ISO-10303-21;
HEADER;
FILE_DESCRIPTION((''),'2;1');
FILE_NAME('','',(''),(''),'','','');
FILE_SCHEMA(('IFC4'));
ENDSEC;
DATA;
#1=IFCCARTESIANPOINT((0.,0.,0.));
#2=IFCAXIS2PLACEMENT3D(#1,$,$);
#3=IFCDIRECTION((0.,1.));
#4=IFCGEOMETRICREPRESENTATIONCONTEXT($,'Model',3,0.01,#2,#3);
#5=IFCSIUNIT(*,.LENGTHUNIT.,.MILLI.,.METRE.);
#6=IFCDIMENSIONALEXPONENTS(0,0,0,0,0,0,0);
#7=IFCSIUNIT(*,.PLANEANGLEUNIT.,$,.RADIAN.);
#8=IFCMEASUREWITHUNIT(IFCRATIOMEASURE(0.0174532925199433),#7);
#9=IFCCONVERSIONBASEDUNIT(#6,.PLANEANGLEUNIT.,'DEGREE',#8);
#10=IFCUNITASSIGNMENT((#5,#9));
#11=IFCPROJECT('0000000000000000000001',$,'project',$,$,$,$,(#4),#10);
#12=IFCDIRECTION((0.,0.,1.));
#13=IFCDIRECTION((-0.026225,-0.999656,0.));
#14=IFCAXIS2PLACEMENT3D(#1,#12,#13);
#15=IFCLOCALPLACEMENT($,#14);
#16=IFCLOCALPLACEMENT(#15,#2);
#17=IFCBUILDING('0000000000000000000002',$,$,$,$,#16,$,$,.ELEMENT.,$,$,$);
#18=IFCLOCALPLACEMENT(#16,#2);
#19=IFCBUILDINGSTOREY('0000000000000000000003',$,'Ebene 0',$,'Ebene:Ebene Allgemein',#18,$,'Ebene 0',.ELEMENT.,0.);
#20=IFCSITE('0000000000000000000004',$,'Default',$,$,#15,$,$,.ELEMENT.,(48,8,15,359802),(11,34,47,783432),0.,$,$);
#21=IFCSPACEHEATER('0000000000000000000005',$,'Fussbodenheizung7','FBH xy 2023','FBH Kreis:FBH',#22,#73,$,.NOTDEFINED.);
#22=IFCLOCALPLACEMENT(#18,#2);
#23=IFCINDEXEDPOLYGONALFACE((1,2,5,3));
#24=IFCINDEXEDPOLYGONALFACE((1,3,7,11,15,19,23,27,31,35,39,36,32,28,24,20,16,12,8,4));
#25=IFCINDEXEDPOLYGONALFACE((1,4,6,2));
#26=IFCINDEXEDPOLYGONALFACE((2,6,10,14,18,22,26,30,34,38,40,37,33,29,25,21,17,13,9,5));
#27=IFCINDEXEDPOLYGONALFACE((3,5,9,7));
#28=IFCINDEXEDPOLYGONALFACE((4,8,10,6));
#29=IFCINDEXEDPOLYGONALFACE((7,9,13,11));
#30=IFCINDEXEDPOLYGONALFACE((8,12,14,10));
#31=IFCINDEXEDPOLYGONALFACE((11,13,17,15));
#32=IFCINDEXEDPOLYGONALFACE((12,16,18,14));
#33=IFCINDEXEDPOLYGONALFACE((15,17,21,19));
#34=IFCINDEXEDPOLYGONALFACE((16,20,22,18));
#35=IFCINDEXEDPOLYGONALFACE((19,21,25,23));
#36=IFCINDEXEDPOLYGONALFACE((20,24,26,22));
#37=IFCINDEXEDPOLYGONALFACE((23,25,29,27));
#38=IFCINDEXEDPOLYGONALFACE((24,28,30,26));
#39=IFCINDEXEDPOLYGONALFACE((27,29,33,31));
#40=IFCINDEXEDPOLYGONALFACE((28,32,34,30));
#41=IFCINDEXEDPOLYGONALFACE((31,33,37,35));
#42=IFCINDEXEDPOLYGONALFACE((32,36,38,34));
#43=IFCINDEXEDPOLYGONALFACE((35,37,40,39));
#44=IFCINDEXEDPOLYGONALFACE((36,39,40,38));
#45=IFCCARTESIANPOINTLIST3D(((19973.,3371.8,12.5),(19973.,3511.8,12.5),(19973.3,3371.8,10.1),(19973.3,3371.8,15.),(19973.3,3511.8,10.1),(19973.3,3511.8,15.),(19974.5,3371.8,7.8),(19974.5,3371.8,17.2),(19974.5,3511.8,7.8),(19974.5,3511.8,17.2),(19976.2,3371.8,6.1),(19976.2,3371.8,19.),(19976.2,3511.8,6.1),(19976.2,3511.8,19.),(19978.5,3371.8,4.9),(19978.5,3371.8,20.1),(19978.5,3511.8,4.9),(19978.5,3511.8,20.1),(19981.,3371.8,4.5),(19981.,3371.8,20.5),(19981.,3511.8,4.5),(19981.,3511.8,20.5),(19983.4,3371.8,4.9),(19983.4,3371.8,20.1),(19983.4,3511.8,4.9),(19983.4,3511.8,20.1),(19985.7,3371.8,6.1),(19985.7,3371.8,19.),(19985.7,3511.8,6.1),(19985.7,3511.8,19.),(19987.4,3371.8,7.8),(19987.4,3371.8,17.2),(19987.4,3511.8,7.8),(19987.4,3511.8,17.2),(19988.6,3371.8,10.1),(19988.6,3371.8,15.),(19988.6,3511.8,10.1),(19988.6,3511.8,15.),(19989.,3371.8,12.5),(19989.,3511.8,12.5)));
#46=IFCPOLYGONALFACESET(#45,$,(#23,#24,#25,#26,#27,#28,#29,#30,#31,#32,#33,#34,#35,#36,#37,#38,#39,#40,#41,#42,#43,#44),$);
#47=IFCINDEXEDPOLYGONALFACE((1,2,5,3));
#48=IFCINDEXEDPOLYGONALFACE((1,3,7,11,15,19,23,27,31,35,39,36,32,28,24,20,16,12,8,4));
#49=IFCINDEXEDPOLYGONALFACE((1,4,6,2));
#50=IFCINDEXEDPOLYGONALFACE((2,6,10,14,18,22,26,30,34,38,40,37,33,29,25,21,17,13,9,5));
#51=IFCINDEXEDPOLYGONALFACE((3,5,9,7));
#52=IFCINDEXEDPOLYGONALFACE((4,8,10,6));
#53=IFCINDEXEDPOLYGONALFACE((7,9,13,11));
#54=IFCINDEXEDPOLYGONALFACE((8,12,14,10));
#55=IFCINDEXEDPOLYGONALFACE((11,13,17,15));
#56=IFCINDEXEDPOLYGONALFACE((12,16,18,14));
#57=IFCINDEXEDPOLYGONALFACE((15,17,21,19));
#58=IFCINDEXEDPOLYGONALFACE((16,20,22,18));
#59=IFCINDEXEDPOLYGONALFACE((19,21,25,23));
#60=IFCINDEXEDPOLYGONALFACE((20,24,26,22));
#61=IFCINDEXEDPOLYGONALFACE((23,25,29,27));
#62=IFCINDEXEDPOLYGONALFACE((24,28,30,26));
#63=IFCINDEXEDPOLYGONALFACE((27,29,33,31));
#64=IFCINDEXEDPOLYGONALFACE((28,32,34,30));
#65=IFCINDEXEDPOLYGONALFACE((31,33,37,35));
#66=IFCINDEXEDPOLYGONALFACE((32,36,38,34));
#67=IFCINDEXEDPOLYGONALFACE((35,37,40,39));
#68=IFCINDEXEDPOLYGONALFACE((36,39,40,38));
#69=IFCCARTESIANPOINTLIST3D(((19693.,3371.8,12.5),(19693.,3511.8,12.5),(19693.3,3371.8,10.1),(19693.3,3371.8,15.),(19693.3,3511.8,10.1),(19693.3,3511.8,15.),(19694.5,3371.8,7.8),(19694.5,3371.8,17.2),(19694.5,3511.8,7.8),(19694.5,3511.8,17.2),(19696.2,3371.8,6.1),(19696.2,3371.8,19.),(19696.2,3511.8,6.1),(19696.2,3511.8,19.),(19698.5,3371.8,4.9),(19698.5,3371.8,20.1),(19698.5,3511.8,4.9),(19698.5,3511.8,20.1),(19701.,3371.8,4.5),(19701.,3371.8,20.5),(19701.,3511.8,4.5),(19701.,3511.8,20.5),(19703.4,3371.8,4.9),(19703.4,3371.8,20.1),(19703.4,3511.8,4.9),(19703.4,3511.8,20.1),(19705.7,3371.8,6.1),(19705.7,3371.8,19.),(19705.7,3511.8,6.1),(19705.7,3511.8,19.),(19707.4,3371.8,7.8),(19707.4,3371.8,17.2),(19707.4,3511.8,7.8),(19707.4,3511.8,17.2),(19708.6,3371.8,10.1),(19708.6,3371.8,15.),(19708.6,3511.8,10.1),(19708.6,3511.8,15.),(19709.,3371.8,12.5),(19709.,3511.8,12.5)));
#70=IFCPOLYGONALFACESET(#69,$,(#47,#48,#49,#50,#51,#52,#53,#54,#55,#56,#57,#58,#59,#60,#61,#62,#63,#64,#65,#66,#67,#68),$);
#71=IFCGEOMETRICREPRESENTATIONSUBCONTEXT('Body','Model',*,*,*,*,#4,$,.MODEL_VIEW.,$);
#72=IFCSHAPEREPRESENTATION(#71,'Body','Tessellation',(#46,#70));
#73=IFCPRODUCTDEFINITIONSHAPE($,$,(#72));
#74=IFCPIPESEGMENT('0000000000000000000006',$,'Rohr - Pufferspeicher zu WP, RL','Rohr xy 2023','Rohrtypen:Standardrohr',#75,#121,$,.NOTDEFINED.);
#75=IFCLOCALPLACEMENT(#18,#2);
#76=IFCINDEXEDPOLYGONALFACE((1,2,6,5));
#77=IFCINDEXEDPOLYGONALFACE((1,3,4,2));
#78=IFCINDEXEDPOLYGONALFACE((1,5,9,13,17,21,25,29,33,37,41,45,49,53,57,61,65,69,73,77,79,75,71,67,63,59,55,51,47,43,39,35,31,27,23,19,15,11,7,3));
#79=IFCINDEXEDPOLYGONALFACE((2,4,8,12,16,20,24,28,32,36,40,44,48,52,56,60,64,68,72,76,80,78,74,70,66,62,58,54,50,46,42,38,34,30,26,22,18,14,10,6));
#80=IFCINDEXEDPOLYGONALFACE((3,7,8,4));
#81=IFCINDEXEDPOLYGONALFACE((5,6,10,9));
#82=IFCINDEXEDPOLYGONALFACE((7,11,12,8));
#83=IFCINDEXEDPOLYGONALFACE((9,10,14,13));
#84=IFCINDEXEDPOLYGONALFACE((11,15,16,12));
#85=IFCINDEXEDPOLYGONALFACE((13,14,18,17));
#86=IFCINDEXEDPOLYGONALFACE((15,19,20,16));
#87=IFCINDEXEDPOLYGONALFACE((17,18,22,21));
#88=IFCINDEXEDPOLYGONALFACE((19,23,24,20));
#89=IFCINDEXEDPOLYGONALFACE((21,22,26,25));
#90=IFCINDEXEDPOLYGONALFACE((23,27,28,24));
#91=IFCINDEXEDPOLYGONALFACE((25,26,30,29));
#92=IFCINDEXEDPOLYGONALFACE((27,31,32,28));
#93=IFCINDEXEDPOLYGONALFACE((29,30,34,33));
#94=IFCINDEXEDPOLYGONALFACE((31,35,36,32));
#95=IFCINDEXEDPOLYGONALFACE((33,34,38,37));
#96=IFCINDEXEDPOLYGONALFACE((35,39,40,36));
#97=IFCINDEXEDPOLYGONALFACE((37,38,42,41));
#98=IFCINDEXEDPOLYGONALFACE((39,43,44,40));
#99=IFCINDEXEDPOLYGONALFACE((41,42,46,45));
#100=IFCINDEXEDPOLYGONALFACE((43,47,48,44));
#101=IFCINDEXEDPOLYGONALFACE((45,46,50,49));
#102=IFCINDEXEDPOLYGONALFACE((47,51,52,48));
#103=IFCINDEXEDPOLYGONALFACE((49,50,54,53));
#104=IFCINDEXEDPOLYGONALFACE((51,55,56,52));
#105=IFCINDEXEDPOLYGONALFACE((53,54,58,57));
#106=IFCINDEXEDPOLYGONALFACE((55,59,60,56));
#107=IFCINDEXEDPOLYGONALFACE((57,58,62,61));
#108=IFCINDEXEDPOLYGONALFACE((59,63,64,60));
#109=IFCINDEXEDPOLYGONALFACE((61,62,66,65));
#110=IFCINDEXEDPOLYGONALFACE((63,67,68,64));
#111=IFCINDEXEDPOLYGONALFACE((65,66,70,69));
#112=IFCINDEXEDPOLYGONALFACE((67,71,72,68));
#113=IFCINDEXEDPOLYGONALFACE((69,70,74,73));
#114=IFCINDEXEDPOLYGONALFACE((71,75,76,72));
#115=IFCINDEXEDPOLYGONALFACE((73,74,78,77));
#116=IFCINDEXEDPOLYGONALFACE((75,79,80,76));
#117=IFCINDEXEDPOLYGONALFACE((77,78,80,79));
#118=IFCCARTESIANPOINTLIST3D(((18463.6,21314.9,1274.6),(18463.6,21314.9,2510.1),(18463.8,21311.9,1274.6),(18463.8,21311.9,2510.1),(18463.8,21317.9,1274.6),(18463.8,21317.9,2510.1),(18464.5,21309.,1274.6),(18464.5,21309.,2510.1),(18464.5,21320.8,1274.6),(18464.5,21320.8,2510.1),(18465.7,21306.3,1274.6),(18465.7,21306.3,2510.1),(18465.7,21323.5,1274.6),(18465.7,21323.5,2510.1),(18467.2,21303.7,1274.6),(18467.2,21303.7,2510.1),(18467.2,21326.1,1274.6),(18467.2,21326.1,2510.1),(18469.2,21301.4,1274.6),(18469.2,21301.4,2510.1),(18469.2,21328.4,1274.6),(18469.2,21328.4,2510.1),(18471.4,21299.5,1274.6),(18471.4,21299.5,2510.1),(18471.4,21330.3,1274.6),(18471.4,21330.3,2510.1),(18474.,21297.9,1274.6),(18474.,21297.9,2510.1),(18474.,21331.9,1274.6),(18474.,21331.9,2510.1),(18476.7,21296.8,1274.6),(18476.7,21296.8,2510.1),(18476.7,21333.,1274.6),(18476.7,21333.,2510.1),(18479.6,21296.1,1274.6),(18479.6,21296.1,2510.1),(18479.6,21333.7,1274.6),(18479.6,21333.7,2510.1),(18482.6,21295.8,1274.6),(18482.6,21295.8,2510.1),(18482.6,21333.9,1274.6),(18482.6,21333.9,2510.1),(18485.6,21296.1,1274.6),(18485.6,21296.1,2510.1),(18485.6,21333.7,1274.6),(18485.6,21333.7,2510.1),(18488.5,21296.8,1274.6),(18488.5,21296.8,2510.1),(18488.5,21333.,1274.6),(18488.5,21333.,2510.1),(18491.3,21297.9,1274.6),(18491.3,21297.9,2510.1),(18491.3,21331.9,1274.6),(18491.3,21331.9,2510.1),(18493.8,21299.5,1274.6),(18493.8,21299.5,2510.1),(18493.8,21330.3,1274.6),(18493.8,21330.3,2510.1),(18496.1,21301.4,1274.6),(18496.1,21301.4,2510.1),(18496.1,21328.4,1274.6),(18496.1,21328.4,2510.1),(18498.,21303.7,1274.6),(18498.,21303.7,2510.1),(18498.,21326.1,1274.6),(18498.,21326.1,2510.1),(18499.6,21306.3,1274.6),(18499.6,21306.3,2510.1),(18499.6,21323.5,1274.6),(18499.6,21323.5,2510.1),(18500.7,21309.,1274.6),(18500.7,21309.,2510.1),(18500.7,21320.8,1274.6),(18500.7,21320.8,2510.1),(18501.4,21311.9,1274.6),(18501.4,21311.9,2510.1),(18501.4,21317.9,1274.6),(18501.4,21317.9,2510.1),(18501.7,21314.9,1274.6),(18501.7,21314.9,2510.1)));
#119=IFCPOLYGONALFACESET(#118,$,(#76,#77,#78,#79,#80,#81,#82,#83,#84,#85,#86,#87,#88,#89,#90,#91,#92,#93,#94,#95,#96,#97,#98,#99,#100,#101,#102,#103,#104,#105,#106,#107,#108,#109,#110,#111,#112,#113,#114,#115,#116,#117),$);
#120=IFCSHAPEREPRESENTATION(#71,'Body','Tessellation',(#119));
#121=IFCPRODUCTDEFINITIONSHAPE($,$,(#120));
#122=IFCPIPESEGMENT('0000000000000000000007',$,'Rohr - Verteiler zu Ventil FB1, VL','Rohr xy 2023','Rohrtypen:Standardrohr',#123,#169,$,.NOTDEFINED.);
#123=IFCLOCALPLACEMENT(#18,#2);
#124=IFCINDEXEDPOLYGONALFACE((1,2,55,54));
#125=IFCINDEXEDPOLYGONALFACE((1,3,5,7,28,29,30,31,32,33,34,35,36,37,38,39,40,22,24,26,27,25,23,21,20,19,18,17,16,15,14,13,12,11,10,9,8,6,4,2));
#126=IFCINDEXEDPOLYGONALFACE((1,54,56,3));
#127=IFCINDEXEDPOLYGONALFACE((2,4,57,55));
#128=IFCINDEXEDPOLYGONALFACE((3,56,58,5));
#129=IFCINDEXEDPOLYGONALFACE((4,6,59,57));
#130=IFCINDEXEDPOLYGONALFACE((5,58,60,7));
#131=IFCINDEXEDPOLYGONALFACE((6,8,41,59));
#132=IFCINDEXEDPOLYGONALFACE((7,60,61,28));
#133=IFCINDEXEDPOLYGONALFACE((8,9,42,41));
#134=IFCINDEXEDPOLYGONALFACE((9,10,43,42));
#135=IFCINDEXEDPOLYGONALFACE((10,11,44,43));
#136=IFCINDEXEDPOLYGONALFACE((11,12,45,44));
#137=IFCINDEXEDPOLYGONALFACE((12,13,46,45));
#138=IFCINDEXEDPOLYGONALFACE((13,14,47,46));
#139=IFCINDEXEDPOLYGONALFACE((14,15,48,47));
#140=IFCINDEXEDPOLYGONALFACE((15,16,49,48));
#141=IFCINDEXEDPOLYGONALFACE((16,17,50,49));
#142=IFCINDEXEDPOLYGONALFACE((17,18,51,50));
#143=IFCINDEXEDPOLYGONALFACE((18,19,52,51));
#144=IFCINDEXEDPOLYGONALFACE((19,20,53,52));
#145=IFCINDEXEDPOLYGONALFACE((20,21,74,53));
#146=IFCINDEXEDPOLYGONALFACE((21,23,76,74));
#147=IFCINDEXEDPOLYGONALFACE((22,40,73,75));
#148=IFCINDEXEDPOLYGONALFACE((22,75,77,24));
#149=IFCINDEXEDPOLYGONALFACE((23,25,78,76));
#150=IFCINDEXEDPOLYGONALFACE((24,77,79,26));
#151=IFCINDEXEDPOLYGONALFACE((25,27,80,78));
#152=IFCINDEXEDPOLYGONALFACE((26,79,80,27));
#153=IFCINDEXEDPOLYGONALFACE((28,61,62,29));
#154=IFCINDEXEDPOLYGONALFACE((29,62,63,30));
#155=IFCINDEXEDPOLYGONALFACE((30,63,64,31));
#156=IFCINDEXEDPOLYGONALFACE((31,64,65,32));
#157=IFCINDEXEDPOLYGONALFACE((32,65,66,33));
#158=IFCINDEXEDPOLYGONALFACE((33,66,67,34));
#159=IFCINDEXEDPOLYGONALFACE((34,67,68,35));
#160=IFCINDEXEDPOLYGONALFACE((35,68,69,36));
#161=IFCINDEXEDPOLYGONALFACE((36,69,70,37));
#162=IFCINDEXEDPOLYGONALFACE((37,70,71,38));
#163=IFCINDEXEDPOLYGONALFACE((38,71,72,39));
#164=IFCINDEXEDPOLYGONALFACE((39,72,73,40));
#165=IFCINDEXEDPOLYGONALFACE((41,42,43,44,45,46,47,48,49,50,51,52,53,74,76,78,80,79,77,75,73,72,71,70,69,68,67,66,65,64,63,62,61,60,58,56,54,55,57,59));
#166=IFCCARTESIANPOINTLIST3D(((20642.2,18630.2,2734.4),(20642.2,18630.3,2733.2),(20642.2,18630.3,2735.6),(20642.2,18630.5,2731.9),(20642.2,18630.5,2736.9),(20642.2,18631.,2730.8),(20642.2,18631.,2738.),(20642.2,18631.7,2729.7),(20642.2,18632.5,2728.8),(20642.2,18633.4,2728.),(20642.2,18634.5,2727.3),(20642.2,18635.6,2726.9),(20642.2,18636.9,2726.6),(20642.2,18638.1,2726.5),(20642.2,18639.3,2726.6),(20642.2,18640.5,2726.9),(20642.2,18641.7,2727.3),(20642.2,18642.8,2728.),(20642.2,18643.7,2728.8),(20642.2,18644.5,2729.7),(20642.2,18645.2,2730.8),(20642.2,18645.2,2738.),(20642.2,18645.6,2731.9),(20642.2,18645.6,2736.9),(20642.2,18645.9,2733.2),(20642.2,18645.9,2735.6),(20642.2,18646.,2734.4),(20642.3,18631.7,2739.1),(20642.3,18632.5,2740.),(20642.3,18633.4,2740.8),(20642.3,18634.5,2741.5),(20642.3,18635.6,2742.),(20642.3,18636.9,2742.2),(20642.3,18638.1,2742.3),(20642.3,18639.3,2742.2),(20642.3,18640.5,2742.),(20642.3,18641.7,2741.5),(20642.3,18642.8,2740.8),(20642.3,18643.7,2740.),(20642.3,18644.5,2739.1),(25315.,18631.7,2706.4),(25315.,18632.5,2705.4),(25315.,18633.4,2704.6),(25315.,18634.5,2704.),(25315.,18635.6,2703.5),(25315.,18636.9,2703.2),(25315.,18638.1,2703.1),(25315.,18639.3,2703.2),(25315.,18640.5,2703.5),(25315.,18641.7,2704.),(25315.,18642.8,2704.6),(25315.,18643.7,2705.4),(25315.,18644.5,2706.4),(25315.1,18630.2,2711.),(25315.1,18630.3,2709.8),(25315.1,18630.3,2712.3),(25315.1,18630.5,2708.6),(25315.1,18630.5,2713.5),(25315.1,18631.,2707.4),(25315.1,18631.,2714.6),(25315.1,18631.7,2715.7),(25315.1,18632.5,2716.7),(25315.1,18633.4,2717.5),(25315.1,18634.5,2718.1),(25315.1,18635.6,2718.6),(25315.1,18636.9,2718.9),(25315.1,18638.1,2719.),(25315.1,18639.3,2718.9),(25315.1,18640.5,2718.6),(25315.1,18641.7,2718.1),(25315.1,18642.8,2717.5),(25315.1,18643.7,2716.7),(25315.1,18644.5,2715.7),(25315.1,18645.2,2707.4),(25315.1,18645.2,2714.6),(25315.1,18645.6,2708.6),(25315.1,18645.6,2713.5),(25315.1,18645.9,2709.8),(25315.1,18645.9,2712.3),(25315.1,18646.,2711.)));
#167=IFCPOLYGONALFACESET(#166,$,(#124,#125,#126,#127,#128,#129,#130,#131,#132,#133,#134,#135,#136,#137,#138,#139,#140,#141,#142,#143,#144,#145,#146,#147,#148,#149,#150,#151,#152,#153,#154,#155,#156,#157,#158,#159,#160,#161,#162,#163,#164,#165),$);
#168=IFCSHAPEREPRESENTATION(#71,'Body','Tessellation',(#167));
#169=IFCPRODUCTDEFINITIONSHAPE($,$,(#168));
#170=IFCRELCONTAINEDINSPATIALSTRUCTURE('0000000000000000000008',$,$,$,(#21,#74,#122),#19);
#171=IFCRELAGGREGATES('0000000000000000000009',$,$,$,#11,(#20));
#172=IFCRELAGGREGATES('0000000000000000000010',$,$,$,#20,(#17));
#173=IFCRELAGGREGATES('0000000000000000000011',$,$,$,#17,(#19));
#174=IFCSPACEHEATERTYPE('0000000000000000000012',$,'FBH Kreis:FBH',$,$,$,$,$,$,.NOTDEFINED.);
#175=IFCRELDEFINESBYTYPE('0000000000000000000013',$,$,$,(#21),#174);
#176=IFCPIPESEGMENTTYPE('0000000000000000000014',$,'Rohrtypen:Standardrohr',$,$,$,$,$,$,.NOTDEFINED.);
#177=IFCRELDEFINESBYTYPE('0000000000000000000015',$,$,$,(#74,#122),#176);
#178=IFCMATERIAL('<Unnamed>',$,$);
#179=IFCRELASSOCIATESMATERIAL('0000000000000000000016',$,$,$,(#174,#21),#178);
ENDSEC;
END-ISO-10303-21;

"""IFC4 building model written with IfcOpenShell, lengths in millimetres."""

from ifc_helpers import new_model, entity, si_unit, converted_unit, direction, frame, origin, place, context, subcontext, project, spatial, indexed_curve, outline, extrude, source, transform, mapped, material, type_object, type_shapes, element, save


model = new_model("IFC4")

# Units and contexts
model_context = context("Model", 3, precision=0.01, world=origin(), true_north=direction((0.0, 1.0)))
body_context = subcontext(model_context, "Body", "Model", "MODEL_VIEW")
ifc_project = project(units=[si_unit("LENGTHUNIT", "METRE", prefix="MILLI"), converted_unit("PLANEANGLEUNIT", "DEGREE", entity("IfcRatioMeasure", 0.0174532925199433), si_unit("PLANEANGLEUNIT", "RADIAN"), dimensions=[0, 0, 0, 0, 0, 0, 0])], contexts=[model_context])

# Site, building, storey
site_placement = place(None, frame((0.0, 0.0, 0.0), z_axis=(0.0, 0.0, 1.0), x_axis=(-0.026225, -0.999656, 0.0)))
site = spatial("IfcSite", under=ifc_project, at=site_placement, Name="Default", CompositionType="ELEMENT", RefLatitude=(48, 8, 15, 359802), RefLongitude=(11, 34, 47, 783432), RefElevation=0.0)
building_placement = place(site_placement, origin())
building = spatial("IfcBuilding", under=site, at=building_placement, CompositionType="ELEMENT")
storey_placement = place(building_placement, origin())
storey = spatial("IfcBuildingStorey", under=building, at=storey_placement, Name="Ebene 0", ObjectType="Ebene:Ebene Allgemein", LongName="Ebene 0", CompositionType="ELEMENT", Elevation=0.0)

# Space heater
ifc_material = material(Name="<Unnamed>")
space_heater_type = type_object("IfcSpaceHeaterType", Name="FBH Kreis:FBH", PredefinedType="NOTDEFINED", material=ifc_material)
shared_shape = source(origin(), body_context, "Body", "SweptSolid", [
    extrude(outline(indexed_curve([(8.0, 0.0), (7.6, 2.5), (6.5, 4.7), (4.7, 6.5), (2.5, 7.6), (0.0, 8.0), (-2.5, 7.6), (-4.7, 6.5), (-6.5, 4.7), (-7.6, 2.5), (-8.0, 0.0), (-7.6, -2.5), (-6.5, -4.7), (-4.7, -6.5), (-2.5, -7.6), (0.0, -8.0), (2.5, -7.6), (4.7, -6.5), (6.5, -4.7), (7.6, -2.5), (8.0, 0.0)], self_intersect=False)), frame((140.0, -1621.8, -83.0), z_axis=(0.0, 1.0, 0.0), x_axis=(1.0, 0.0, 0.0)), (0.0, 0.0, 1.0), 140.0),
    extrude(outline(indexed_curve([(8.0, 0.0), (7.6, 2.5), (6.5, 4.7), (4.7, 6.5), (2.5, 7.6), (0.0, 8.0), (-2.5, 7.6), (-4.7, 6.5), (-6.5, 4.7), (-7.6, 2.5), (-8.0, 0.0), (-7.6, -2.5), (-6.5, -4.7), (-4.7, -6.5), (-2.5, -7.6), (0.0, -8.0), (2.5, -7.6), (4.7, -6.5), (6.5, -4.7), (7.6, -2.5), (8.0, 0.0)], self_intersect=False)), frame((-140.0, -1621.8, -83.0), z_axis=(0.0, 1.0, 0.0), x_axis=(1.0, 0.0, 0.0)), (0.0, 0.0, 1.0), 140.0),
])
type_shapes(space_heater_type, [shared_shape])
for number, where, name in (
    (1, (19841.0, 4993.5, 95.5), "Fussbodenheizung7"),
):
    element("IfcSpaceHeater", number, at=place(storey_placement, frame(where)), inside=storey, type_object=space_heater_type, material=ifc_material, Name=name, Description="FBH xy 2023", ObjectType="FBH Kreis:FBH", PredefinedType="NOTDEFINED", context=body_context, shape_type="MappedRepresentation", body=[
        mapped(shared_shape, transform((0.0, 0.0, 0.0), scale=1.0)),
    ])

# Pipe segments
pipe_segment_type = type_object("IfcPipeSegmentType", Name="Rohrtypen:Standardrohr", PredefinedType="NOTDEFINED")
pipe_segment_1_placement = place(storey_placement, origin())
element("IfcPipeSegment", 2, at=pipe_segment_1_placement, inside=storey, type_object=pipe_segment_type, Name="Rohr - Pufferspeicher zu WP, RL", Description="Rohr xy 2023", ObjectType="Rohrtypen:Standardrohr", PredefinedType="NOTDEFINED", context=body_context, shape_type="SweptSolid", body=[
    extrude(outline(indexed_curve([(19.1, 0.0), (18.8, 3.0), (18.1, 5.9), (17.0, 8.6), (15.4, 11.2), (13.5, 13.5), (11.2, 15.4), (8.6, 17.0), (5.9, 18.1), (3.0, 18.8), (0.0, 19.1), (-3.0, 18.8), (-5.9, 18.1), (-8.6, 17.0), (-11.2, 15.4), (-13.5, 13.5), (-15.4, 11.2), (-17.0, 8.6), (-18.1, 5.9), (-18.8, 3.0), (-19.1, 0.0), (-18.8, -3.0), (-18.1, -5.9), (-17.0, -8.6), (-15.4, -11.2), (-13.5, -13.5), (-11.2, -15.4), (-8.6, -17.0), (-5.9, -18.1), (-3.0, -18.8), (0.0, -19.1), (3.0, -18.8), (5.9, -18.1), (8.6, -17.0), (11.2, -15.4), (13.5, -13.5), (15.4, -11.2), (17.0, -8.6), (18.1, -5.9), (18.8, -3.0), (19.1, 0.0)], self_intersect=False)), frame((18482.6, 21314.9, 1274.6), z_axis=(0.0, 0.0, 1.0), x_axis=(-1.0, 0.0, 0.0)), (0.0, 0.0, 1.0), 1235.5),
])
pipe_segment_2_placement = place(storey_placement, origin())
element("IfcPipeSegment", 3, at=pipe_segment_2_placement, inside=storey, type_object=pipe_segment_type, Name="Rohr - Verteiler zu Ventil FB1, VL", Description="Rohr xy 2023", ObjectType="Rohrtypen:Standardrohr", PredefinedType="NOTDEFINED", context=body_context, shape_type="SweptSolid", body=[
    extrude(outline(indexed_curve([(7.9, 0.0), (7.8, 1.2), (7.6, 2.5), (7.1, 3.6), (6.4, 4.7), (5.6, 5.6), (4.7, 6.4), (3.6, 7.1), (2.5, 7.6), (1.2, 7.8), (0.0, 7.9), (-1.2, 7.8), (-2.5, 7.6), (-3.6, 7.1), (-4.7, 6.4), (-5.6, 5.6), (-6.4, 4.7), (-7.1, 3.6), (-7.6, 2.5), (-7.8, 1.2), (-7.9, 0.0), (-7.8, -1.2), (-7.6, -2.5), (-7.1, -3.6), (-6.4, -4.7), (-5.6, -5.6), (-4.7, -6.4), (-3.6, -7.1), (-2.5, -7.6), (-1.2, -7.8), (0.0, -7.9), (1.2, -7.8), (2.5, -7.6), (3.6, -7.1), (4.7, -6.4), (5.6, -5.6), (6.4, -4.7), (7.1, -3.6), (7.6, -2.5), (7.8, -1.2), (7.9, 0.0)], self_intersect=False)), frame((25315.1, 18638.1, 2711.0), z_axis=(-0.999988, 0.0, 0.005), x_axis=(0.0, 1.0, 0.0)), (0.0, 0.0, 1.0), 4672.9),
])

save(model, "model.ifc")
